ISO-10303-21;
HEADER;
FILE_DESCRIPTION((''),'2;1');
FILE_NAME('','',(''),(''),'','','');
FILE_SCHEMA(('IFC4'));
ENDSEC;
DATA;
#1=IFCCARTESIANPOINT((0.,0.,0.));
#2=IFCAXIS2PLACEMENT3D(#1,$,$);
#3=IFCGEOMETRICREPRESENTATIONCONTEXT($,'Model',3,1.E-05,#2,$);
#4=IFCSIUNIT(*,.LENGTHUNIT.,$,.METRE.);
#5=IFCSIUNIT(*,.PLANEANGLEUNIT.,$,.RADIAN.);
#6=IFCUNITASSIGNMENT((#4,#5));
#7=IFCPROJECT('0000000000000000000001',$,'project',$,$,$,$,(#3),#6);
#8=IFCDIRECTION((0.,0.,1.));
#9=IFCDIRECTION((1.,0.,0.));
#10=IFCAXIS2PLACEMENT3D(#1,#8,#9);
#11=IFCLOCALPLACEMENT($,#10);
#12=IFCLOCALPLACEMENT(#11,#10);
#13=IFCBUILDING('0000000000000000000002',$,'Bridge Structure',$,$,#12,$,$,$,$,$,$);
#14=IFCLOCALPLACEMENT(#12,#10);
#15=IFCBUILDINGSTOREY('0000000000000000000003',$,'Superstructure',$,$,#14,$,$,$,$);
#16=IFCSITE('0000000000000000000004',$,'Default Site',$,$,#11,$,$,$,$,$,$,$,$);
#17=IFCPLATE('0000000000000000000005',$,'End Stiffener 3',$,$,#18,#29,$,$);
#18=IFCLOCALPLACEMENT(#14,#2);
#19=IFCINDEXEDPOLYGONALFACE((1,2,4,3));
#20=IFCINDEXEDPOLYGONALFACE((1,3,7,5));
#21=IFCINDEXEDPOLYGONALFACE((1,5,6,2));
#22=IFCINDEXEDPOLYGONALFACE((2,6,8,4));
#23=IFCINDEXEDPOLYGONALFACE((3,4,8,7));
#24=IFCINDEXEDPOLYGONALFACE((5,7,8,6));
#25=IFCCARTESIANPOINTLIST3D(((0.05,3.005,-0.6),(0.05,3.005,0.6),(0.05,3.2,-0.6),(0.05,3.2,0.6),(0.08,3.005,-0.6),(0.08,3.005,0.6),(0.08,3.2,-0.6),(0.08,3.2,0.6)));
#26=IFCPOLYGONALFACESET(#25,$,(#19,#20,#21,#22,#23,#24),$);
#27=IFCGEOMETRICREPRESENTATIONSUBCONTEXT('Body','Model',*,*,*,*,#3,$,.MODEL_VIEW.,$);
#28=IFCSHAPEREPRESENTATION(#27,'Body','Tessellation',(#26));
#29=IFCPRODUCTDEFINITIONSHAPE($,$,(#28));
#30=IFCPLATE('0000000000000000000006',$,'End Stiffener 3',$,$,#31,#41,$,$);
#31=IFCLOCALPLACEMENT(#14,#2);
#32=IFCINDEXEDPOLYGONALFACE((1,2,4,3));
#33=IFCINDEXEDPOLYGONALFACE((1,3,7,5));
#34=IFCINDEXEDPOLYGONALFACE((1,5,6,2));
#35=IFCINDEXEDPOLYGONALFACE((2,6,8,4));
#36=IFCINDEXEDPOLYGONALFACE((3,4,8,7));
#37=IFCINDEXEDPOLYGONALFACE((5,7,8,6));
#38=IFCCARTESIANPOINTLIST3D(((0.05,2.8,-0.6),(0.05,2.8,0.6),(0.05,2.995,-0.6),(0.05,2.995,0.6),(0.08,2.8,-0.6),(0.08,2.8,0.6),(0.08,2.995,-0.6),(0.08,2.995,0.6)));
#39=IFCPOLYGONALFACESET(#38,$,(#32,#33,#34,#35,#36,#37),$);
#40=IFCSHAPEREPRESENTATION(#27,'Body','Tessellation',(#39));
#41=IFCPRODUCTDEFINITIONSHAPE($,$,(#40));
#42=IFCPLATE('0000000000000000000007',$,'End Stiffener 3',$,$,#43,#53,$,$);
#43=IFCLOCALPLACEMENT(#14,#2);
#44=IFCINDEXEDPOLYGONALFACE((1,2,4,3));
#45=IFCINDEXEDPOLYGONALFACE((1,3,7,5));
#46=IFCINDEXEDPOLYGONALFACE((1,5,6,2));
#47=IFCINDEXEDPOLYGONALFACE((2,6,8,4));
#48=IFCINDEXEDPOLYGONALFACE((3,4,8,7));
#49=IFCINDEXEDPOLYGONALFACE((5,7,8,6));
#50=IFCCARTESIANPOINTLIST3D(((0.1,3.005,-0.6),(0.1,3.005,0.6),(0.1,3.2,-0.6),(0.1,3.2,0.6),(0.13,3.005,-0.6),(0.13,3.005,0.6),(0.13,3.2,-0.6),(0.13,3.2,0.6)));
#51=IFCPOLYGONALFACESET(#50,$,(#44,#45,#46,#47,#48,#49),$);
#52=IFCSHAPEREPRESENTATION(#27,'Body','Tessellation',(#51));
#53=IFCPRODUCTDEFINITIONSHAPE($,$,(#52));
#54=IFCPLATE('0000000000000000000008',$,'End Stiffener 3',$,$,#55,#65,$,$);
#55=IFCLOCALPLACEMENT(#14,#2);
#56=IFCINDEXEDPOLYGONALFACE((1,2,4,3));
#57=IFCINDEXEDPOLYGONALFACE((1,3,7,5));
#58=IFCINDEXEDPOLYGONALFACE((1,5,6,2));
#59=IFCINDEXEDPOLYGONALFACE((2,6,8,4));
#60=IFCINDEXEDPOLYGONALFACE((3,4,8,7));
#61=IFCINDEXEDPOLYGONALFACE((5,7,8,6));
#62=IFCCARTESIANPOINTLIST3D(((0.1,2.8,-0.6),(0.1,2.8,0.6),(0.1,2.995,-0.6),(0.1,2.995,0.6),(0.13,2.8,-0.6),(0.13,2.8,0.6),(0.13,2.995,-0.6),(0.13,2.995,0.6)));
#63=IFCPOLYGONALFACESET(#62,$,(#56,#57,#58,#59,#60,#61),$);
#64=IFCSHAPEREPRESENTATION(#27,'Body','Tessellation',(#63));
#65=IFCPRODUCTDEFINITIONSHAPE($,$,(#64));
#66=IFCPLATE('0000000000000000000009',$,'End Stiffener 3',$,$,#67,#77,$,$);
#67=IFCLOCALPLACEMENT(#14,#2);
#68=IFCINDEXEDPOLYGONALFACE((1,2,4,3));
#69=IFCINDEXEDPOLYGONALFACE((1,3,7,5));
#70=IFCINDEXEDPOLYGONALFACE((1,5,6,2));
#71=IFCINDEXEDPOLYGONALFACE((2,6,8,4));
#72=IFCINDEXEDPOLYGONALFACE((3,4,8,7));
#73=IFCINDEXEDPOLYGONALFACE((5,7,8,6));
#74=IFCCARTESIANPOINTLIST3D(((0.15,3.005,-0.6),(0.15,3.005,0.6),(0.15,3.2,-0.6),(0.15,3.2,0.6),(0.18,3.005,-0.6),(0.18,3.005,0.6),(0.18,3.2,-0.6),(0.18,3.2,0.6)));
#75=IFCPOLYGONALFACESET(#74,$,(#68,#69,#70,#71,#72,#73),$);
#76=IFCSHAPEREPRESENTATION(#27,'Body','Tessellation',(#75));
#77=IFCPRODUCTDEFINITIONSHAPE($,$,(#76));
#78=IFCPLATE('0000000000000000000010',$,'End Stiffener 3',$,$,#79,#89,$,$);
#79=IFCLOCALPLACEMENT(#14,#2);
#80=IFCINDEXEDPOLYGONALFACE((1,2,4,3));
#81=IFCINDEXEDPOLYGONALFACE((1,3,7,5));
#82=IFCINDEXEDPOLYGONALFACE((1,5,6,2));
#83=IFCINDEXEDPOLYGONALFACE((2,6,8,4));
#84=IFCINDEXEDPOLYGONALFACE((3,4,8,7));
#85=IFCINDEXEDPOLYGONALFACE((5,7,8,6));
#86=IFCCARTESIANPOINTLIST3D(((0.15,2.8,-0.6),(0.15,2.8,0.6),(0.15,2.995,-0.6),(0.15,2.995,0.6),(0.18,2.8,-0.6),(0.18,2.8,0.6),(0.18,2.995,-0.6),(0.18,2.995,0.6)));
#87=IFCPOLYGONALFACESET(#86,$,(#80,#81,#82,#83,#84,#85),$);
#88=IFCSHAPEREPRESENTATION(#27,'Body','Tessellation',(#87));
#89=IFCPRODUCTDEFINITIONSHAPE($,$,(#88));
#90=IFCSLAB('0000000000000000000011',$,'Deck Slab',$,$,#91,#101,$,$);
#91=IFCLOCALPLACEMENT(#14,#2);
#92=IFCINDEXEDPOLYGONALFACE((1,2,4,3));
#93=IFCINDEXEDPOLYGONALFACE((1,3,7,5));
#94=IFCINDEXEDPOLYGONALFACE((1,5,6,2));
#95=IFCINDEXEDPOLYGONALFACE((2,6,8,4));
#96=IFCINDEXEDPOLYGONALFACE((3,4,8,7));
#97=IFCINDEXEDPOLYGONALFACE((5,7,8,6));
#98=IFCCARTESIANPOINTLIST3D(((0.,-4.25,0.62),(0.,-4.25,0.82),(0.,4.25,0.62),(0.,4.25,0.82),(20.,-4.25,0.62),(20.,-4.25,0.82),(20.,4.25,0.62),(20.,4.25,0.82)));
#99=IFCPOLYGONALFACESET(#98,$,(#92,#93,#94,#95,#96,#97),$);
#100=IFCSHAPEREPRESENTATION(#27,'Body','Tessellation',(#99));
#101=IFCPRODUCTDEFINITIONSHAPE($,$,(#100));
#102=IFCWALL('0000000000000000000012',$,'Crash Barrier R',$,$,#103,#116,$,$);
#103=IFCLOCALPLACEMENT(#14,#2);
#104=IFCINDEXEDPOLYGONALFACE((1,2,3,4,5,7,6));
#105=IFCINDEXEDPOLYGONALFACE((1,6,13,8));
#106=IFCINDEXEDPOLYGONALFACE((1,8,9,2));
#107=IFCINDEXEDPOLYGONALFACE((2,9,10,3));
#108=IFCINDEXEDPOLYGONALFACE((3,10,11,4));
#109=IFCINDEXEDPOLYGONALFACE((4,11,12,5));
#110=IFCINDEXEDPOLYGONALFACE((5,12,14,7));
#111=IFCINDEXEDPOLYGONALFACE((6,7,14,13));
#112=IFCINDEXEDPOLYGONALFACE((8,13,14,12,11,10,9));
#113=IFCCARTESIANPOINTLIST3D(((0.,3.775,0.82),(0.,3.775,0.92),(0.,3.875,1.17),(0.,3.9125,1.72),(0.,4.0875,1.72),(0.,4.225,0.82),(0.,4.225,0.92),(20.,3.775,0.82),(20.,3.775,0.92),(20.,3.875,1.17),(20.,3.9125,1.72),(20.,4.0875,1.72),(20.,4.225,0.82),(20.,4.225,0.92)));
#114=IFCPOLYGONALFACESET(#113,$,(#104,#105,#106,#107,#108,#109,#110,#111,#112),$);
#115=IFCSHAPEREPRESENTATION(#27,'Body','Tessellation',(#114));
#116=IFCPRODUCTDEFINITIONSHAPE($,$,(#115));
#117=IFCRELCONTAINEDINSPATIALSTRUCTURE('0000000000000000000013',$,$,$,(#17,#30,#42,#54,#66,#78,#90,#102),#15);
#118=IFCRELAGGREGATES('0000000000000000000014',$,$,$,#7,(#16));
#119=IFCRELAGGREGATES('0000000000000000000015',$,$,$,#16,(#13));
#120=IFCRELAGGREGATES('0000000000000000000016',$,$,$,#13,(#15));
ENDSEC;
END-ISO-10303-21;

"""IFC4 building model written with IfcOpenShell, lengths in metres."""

from ifc_helpers import new_model, si_unit, frame, origin, origin_with_axes, origin_2d_with_axis, place, context, subcontext, project, spatial, polyline, rectangle, outline, extrude, element, save


model = new_model("IFC4")

# Units and contexts
model_context = context("Model", 3, precision=1e-05, world=origin())
body_context = subcontext(model_context, "Body", "Model", "MODEL_VIEW")
ifc_project = project(units=[si_unit("LENGTHUNIT", "METRE"), si_unit("PLANEANGLEUNIT", "RADIAN")], contexts=[model_context])

# Site, building, storey
site_placement = place(None, origin_with_axes())
site = spatial("IfcSite", under=ifc_project, at=site_placement, Name="Default Site")
building_placement = place(site_placement, origin_with_axes())
building = spatial("IfcBuilding", under=site, at=building_placement, Name="Bridge Structure")
storey_placement = place(building_placement, origin_with_axes())
storey = spatial("IfcBuildingStorey", under=building, at=storey_placement, Name="Superstructure")

# Plates
for number, where, z_axis, x_axis, name in (
    (1, (0.065, 3.1025, -0.6), (0.0, 0.0, 1.0), (1.0, 0.0, 0.0), "End Stiffener 3"),
    (2, (0.065, 2.8975, -0.6), (0.0, 0.0, 1.0), (1.0, 0.0, 0.0), "End Stiffener 3"),
    (3, (0.115, 3.1025, -0.6), (0.0, 0.0, 1.0), (1.0, 0.0, 0.0), "End Stiffener 3"),
    (4, (0.115, 2.8975, -0.6), (0.0, 0.0, 1.0), (1.0, 0.0, 0.0), "End Stiffener 3"),
    (5, (0.165, 3.1025, -0.6), (0.0, 0.0, 1.0), (1.0, 0.0, 0.0), "End Stiffener 3"),
    (6, (0.165, 2.8975, -0.6), (0.0, 0.0, 1.0), (1.0, 0.0, 0.0), "End Stiffener 3"),
):
    element("IfcPlate", number, at=place(storey_placement, frame(where, z_axis=z_axis, x_axis=x_axis)), inside=storey, Name=name, context=body_context, shape_type="SweptSolid", body=[
        extrude(rectangle(XDim=0.03, YDim=0.195, at=origin_2d_with_axis()), origin_with_axes(), (0.0, 0.0, 1.0), 1.2),
    ])

# Slab
slab_placement = place(storey_placement, frame((0.0, 0.0, 0.62), z_axis=(0.0, 0.0, 1.0), x_axis=(1.0, 0.0, 0.0)))
element("IfcSlab", 7, at=slab_placement, inside=storey, Name="Deck Slab", context=body_context, shape_type="SweptSolid", body=[
    extrude(outline(polyline([(0.0, -4.25), (20.0, -4.25), (20.0, 4.25), (0.0, 4.25), (0.0, -4.25)])), origin_with_axes(), (0.0, 0.0, 1.0), 0.2),
])

# Wall
wall_placement = place(storey_placement, frame((0.0, 3.775, 0.82), z_axis=(1.0, 0.0, 0.0), x_axis=(0.0, 1.0, 0.0)))
element("IfcWall", 8, at=wall_placement, inside=storey, Name="Crash Barrier R", context=body_context, shape_type="SweptSolid", body=[
    extrude(outline(polyline([(0.45, 0.0), (0.0, 0.0), (0.0, 0.1), (0.1, 0.35), (0.1375, 0.9), (0.3125, 0.9), (0.45, 0.1), (0.45, 0.0)])), origin_with_axes(), (0.0, 0.0, 1.0), 20.0),
])

save(model, "model.ifc")
